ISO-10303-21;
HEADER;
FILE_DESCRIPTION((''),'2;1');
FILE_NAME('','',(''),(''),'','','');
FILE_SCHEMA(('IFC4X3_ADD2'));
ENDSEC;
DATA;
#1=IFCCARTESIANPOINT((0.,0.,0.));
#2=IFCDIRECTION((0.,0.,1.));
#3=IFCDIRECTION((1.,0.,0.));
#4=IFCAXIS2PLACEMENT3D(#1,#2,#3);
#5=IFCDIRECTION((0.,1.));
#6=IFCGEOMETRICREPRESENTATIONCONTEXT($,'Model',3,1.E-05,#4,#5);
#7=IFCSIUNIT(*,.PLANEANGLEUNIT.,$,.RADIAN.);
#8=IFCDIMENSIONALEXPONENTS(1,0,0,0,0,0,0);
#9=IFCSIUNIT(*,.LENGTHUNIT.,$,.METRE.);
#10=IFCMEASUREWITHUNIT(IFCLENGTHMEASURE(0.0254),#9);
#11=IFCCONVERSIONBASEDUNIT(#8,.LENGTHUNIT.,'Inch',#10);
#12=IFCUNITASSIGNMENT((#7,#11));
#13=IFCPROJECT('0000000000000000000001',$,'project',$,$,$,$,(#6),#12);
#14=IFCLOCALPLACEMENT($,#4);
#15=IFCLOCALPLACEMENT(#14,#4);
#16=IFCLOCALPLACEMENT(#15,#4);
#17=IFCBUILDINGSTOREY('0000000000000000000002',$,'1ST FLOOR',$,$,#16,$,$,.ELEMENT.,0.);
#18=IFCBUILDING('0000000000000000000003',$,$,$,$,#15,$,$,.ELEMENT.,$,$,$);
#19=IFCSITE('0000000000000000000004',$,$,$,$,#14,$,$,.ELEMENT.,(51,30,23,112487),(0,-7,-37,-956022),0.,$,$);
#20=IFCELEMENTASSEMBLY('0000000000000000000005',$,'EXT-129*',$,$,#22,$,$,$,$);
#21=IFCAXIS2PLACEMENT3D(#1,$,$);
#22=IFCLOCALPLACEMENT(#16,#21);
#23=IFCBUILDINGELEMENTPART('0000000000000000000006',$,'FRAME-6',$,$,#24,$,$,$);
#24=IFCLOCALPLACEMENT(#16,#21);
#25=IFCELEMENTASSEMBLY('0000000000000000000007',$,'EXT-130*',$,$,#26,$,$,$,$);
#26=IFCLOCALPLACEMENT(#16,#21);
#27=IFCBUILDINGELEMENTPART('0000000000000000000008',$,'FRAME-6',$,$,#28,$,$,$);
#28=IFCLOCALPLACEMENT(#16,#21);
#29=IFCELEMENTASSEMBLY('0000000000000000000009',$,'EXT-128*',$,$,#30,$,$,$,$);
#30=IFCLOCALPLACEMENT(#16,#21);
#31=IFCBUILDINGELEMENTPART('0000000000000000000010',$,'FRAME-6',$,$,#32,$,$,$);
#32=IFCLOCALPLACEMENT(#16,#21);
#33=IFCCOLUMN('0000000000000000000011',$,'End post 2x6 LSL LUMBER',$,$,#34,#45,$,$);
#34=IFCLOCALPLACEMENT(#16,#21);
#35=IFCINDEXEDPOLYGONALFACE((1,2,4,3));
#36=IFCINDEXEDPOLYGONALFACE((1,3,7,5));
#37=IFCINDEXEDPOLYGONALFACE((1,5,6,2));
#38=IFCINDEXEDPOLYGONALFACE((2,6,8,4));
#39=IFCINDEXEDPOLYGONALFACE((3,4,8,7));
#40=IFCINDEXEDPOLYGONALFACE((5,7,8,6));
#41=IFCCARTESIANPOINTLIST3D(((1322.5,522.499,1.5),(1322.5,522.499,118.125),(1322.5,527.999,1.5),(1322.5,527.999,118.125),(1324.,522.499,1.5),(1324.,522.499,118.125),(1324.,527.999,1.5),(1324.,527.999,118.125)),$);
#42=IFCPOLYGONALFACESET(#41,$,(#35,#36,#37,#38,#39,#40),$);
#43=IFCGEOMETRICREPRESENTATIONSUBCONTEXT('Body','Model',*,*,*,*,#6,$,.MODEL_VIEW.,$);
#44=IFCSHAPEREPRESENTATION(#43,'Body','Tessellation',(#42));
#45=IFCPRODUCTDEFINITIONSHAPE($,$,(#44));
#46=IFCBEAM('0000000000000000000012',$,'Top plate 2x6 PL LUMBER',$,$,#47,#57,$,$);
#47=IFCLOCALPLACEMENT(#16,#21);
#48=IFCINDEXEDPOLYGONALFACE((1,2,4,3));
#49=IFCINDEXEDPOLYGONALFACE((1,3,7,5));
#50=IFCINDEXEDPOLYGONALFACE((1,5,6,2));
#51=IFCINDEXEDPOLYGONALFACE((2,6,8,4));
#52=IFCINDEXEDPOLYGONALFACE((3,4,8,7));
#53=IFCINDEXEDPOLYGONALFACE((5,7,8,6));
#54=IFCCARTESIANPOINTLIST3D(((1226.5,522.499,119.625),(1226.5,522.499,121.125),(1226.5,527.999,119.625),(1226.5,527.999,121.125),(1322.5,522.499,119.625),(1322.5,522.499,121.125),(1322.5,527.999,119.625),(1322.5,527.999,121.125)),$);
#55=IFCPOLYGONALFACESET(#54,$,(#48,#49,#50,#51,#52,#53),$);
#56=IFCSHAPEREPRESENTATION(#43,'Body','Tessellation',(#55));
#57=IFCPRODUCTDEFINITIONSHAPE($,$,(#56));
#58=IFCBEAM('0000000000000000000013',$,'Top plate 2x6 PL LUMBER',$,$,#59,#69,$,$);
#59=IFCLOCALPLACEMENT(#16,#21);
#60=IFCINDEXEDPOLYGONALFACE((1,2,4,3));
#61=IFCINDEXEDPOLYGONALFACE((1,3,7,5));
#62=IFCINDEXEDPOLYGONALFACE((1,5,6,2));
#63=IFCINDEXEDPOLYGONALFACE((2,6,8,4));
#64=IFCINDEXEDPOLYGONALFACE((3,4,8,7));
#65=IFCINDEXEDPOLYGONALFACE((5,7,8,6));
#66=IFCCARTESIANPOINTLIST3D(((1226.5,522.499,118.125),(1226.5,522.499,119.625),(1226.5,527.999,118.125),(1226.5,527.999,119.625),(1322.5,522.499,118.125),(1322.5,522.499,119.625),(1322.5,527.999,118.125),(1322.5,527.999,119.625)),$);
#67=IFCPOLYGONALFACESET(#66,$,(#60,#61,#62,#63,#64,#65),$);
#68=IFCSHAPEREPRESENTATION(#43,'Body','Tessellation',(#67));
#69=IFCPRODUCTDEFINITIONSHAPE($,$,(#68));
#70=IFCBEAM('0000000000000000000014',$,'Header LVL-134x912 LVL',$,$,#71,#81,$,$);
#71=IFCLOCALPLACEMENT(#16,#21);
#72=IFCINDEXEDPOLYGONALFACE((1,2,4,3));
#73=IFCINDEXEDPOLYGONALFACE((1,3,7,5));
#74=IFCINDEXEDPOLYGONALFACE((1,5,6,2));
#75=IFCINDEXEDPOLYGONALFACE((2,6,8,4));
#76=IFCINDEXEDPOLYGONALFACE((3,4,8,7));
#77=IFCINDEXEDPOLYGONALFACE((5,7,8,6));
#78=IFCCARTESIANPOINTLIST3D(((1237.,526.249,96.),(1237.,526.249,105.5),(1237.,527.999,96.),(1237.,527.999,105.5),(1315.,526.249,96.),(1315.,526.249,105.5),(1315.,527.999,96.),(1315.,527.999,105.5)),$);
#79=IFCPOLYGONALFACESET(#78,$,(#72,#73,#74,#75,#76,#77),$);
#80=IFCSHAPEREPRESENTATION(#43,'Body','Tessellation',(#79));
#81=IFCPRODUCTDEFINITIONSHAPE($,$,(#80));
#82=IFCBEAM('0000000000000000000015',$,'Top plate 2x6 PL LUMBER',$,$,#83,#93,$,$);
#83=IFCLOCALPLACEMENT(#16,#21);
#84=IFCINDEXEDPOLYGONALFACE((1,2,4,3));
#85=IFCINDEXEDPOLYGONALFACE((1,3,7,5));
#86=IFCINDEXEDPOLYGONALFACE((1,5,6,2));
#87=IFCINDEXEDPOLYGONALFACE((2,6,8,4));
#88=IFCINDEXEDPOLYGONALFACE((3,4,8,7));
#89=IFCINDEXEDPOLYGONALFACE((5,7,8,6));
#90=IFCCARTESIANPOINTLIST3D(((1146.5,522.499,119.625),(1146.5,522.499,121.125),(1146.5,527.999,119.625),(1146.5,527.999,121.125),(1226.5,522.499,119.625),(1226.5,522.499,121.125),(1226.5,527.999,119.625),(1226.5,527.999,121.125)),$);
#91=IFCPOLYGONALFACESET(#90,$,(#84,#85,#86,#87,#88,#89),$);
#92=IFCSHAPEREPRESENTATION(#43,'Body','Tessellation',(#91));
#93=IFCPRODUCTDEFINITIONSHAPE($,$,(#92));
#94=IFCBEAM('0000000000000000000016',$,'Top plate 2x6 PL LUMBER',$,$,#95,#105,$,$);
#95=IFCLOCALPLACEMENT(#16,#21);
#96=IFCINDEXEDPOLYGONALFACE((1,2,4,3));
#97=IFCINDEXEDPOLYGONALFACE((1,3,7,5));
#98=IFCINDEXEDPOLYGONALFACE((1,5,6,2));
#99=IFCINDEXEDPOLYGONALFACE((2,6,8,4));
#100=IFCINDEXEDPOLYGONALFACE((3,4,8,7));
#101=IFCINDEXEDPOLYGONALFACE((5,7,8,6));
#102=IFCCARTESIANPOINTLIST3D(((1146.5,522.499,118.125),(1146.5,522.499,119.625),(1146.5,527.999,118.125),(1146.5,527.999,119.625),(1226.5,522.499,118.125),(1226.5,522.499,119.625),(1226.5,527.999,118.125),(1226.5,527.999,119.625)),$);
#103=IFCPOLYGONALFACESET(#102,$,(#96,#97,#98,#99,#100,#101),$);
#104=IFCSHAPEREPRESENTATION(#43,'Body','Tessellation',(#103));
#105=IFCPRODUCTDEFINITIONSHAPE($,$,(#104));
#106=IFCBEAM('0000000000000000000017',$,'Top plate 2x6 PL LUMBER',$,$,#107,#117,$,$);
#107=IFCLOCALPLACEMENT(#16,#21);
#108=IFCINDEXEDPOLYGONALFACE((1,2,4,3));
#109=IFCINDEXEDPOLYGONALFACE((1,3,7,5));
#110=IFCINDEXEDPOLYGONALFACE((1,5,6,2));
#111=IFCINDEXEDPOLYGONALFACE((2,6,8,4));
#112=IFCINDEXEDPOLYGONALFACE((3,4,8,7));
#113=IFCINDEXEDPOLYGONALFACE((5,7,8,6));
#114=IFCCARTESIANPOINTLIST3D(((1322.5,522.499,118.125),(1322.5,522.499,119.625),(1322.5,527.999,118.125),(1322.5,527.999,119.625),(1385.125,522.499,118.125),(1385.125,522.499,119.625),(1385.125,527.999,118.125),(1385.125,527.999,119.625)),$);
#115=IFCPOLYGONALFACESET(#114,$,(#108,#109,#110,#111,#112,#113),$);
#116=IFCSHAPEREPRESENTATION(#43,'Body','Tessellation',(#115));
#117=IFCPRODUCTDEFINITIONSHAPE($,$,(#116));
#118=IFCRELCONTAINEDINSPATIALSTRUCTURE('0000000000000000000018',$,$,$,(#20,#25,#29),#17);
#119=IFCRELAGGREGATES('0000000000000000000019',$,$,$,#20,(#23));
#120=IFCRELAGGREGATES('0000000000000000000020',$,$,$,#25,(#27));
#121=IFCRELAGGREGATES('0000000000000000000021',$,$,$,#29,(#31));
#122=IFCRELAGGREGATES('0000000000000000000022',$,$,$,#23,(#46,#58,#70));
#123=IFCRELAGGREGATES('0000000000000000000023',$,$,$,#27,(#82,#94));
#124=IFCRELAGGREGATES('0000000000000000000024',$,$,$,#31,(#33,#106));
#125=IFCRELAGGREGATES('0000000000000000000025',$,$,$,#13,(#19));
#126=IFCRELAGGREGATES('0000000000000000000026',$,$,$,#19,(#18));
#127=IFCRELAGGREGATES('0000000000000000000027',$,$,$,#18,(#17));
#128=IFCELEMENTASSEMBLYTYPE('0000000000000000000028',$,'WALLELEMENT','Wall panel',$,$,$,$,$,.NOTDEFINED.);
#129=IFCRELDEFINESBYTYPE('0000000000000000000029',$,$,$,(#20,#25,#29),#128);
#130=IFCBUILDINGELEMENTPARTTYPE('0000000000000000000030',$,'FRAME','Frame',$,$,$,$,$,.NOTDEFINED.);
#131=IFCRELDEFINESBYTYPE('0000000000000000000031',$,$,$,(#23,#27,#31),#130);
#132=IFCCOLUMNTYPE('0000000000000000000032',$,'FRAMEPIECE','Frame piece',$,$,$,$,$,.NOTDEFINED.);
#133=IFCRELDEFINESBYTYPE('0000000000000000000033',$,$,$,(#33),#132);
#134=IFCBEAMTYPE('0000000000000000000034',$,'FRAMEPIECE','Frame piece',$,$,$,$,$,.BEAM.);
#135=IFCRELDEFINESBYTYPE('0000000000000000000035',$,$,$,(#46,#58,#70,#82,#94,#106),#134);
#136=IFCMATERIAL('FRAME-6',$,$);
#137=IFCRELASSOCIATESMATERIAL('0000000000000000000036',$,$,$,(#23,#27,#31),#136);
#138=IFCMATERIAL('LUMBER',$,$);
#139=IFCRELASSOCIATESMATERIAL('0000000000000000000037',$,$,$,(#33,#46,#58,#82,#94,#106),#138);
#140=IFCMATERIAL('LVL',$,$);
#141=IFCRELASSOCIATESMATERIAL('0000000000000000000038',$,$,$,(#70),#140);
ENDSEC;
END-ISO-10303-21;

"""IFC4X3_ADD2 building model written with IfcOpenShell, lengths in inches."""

from ifc_helpers import new_model, entity, si_unit, converted_unit, direction, frame, origin_with_axes, origin_2d_with_axis, place, context, subcontext, project, spatial, rectangle, extrude, material, type_object, element, aggregate, save


model = new_model("IFC4X3_ADD2")

# Units and contexts
model_context = context("Model", 3, precision=1e-05, world=origin_with_axes(), true_north=direction((0.0, 1.0)))
body_context = subcontext(model_context, "Body", "Model", "MODEL_VIEW")
ifc_project = project(units=[si_unit("PLANEANGLEUNIT", "RADIAN"), converted_unit("LENGTHUNIT", "Inch", entity("IfcLengthMeasure", 0.0254), si_unit("LENGTHUNIT", "METRE"), dimensions=[1, 0, 0, 0, 0, 0, 0])], contexts=[model_context])

# Site, building, storey
site_placement = place(None, origin_with_axes())
site = spatial("IfcSite", under=ifc_project, at=site_placement, CompositionType="ELEMENT", RefLatitude=(51, 30, 23, 112487), RefLongitude=(0, -7, -37, -956022), RefElevation=0.0)
building_placement = place(site_placement, origin_with_axes())
building = spatial("IfcBuilding", under=site, at=building_placement, CompositionType="ELEMENT")
storey_placement = place(building_placement, origin_with_axes())
storey = spatial("IfcBuildingStorey", under=building, at=storey_placement, Name="1ST FLOOR", CompositionType="ELEMENT", Elevation=0.0)

# Element assemblies, building element parts, column
element_assembly_type = type_object("IfcElementAssemblyType", Name="WALLELEMENT", Description="Wall panel", PredefinedType="NOTDEFINED")
assembly_1_placement = place(storey_placement, origin_with_axes())
assembly_1 = element("IfcElementAssembly", 1, at=assembly_1_placement, inside=storey, type_object=element_assembly_type, Name="EXT-129*")
ifc_material_1 = material(Name="FRAME-6")
building_element_part_type = type_object("IfcBuildingElementPartType", Name="FRAME", Description="Frame", PredefinedType="NOTDEFINED")
building_element_part_1_placement = place(storey_placement, origin_with_axes())
building_element_part_1 = element("IfcBuildingElementPart", 2, at=building_element_part_1_placement, type_object=building_element_part_type, material=ifc_material_1, Name="FRAME-6")
aggregate(assembly_1, [building_element_part_1])
ifc_material_2 = material(Name="LUMBER")
column_type = type_object("IfcColumnType", Name="FRAMEPIECE", Description="Frame piece", PredefinedType="NOTDEFINED")
assembly_2_placement = place(storey_placement, origin_with_axes())
assembly_2 = element("IfcElementAssembly", 3, at=assembly_2_placement, inside=storey, type_object=element_assembly_type, Name="EXT-130*")
building_element_part_2_placement = place(storey_placement, origin_with_axes())
building_element_part_2 = element("IfcBuildingElementPart", 4, at=building_element_part_2_placement, type_object=building_element_part_type, material=ifc_material_1, Name="FRAME-6")
aggregate(assembly_2, [building_element_part_2])
assembly_3_placement = place(storey_placement, origin_with_axes())
assembly_3 = element("IfcElementAssembly", 5, at=assembly_3_placement, inside=storey, type_object=element_assembly_type, Name="EXT-128*")
building_element_part_3_placement = place(storey_placement, origin_with_axes())
building_element_part_3 = element("IfcBuildingElementPart", 6, at=building_element_part_3_placement, type_object=building_element_part_type, material=ifc_material_1, Name="FRAME-6")
aggregate(assembly_3, [building_element_part_3])
column_1_placement = place(storey_placement, frame((1323.25, 525.249, 118.125), z_axis=(0.0, 0.0, -1.0), x_axis=(1.0, 0.0, 0.0)))
column_1 = element("IfcColumn", 7, at=column_1_placement, type_object=column_type, material=ifc_material_2, Name="End post 2x6 LSL LUMBER", context=body_context, shape_type="SweptSolid", body=[
    extrude(rectangle(XDim=1.5, YDim=5.5, at=origin_2d_with_axis()), origin_with_axes(), (0.0, 0.0, 1.0), 116.625),
])

# Beams
beam_type = type_object("IfcBeamType", Name="FRAMEPIECE", Description="Frame piece", PredefinedType="BEAM")
beam_1_placement = place(storey_placement, frame((1322.5, 525.249, 120.375), z_axis=(-1.0, 0.0, 0.0), x_axis=(0.0, 0.0, -1.0)))
beam_1 = element("IfcBeam", 8, at=beam_1_placement, type_object=beam_type, material=ifc_material_2, Name="Top plate 2x6 PL LUMBER", context=body_context, shape_type="SweptSolid", body=[
    extrude(rectangle(XDim=1.5, YDim=5.5, at=origin_2d_with_axis()), origin_with_axes(), (0.0, 0.0, 1.0), 96.0),
])
beam_2_placement = place(storey_placement, frame((1322.5, 525.249, 118.875), z_axis=(-1.0, 0.0, 0.0), x_axis=(0.0, 0.0, -1.0)))
beam_2 = element("IfcBeam", 9, at=beam_2_placement, type_object=beam_type, material=ifc_material_2, Name="Top plate 2x6 PL LUMBER", context=body_context, shape_type="SweptSolid", body=[
    extrude(rectangle(XDim=1.5, YDim=5.5, at=origin_2d_with_axis()), origin_with_axes(), (0.0, 0.0, 1.0), 96.0),
])
ifc_material_3 = material(Name="LVL")
beam_3_placement = place(storey_placement, frame((1237.0, 527.124, 100.75), z_axis=(1.0, 0.0, 0.0), x_axis=(0.0, 1.0, 0.0)))
beam_3 = element("IfcBeam", 10, at=beam_3_placement, type_object=beam_type, material=ifc_material_3, Name="Header LVL-134x912 LVL", context=body_context, shape_type="SweptSolid", body=[
    extrude(rectangle(XDim=1.75, YDim=9.5, at=origin_2d_with_axis()), origin_with_axes(), (0.0, 0.0, 1.0), 78.0),
])
aggregate(building_element_part_1, [beam_1, beam_2, beam_3])
beam_4_placement = place(storey_placement, frame((1226.5, 525.249, 120.375), z_axis=(-1.0, 0.0, 0.0), x_axis=(0.0, 0.0, -1.0)))
beam_4 = element("IfcBeam", 11, at=beam_4_placement, type_object=beam_type, material=ifc_material_2, Name="Top plate 2x6 PL LUMBER", context=body_context, shape_type="SweptSolid", body=[
    extrude(rectangle(XDim=1.5, YDim=5.5, at=origin_2d_with_axis()), origin_with_axes(), (0.0, 0.0, 1.0), 80.0),
])
beam_5_placement = place(storey_placement, frame((1226.5, 525.249, 118.875), z_axis=(-1.0, 0.0, 0.0), x_axis=(0.0, 0.0, -1.0)))
beam_5 = element("IfcBeam", 12, at=beam_5_placement, type_object=beam_type, material=ifc_material_2, Name="Top plate 2x6 PL LUMBER", context=body_context, shape_type="SweptSolid", body=[
    extrude(rectangle(XDim=1.5, YDim=5.5, at=origin_2d_with_axis()), origin_with_axes(), (0.0, 0.0, 1.0), 80.0),
])
aggregate(building_element_part_2, [beam_4, beam_5])
beam_6_placement = place(storey_placement, frame((1322.5, 525.249, 118.875), z_axis=(1.0, 0.0, 0.0), x_axis=(0.0, 0.0, 1.0)))
beam_6 = element("IfcBeam", 13, at=beam_6_placement, type_object=beam_type, material=ifc_material_2, Name="Top plate 2x6 PL LUMBER", context=body_context, shape_type="SweptSolid", body=[
    extrude(rectangle(XDim=1.5, YDim=5.5, at=origin_2d_with_axis()), origin_with_axes(), (0.0, 0.0, 1.0), 62.625),
])
aggregate(building_element_part_3, [column_1, beam_6])

save(model, "model.ifc")
